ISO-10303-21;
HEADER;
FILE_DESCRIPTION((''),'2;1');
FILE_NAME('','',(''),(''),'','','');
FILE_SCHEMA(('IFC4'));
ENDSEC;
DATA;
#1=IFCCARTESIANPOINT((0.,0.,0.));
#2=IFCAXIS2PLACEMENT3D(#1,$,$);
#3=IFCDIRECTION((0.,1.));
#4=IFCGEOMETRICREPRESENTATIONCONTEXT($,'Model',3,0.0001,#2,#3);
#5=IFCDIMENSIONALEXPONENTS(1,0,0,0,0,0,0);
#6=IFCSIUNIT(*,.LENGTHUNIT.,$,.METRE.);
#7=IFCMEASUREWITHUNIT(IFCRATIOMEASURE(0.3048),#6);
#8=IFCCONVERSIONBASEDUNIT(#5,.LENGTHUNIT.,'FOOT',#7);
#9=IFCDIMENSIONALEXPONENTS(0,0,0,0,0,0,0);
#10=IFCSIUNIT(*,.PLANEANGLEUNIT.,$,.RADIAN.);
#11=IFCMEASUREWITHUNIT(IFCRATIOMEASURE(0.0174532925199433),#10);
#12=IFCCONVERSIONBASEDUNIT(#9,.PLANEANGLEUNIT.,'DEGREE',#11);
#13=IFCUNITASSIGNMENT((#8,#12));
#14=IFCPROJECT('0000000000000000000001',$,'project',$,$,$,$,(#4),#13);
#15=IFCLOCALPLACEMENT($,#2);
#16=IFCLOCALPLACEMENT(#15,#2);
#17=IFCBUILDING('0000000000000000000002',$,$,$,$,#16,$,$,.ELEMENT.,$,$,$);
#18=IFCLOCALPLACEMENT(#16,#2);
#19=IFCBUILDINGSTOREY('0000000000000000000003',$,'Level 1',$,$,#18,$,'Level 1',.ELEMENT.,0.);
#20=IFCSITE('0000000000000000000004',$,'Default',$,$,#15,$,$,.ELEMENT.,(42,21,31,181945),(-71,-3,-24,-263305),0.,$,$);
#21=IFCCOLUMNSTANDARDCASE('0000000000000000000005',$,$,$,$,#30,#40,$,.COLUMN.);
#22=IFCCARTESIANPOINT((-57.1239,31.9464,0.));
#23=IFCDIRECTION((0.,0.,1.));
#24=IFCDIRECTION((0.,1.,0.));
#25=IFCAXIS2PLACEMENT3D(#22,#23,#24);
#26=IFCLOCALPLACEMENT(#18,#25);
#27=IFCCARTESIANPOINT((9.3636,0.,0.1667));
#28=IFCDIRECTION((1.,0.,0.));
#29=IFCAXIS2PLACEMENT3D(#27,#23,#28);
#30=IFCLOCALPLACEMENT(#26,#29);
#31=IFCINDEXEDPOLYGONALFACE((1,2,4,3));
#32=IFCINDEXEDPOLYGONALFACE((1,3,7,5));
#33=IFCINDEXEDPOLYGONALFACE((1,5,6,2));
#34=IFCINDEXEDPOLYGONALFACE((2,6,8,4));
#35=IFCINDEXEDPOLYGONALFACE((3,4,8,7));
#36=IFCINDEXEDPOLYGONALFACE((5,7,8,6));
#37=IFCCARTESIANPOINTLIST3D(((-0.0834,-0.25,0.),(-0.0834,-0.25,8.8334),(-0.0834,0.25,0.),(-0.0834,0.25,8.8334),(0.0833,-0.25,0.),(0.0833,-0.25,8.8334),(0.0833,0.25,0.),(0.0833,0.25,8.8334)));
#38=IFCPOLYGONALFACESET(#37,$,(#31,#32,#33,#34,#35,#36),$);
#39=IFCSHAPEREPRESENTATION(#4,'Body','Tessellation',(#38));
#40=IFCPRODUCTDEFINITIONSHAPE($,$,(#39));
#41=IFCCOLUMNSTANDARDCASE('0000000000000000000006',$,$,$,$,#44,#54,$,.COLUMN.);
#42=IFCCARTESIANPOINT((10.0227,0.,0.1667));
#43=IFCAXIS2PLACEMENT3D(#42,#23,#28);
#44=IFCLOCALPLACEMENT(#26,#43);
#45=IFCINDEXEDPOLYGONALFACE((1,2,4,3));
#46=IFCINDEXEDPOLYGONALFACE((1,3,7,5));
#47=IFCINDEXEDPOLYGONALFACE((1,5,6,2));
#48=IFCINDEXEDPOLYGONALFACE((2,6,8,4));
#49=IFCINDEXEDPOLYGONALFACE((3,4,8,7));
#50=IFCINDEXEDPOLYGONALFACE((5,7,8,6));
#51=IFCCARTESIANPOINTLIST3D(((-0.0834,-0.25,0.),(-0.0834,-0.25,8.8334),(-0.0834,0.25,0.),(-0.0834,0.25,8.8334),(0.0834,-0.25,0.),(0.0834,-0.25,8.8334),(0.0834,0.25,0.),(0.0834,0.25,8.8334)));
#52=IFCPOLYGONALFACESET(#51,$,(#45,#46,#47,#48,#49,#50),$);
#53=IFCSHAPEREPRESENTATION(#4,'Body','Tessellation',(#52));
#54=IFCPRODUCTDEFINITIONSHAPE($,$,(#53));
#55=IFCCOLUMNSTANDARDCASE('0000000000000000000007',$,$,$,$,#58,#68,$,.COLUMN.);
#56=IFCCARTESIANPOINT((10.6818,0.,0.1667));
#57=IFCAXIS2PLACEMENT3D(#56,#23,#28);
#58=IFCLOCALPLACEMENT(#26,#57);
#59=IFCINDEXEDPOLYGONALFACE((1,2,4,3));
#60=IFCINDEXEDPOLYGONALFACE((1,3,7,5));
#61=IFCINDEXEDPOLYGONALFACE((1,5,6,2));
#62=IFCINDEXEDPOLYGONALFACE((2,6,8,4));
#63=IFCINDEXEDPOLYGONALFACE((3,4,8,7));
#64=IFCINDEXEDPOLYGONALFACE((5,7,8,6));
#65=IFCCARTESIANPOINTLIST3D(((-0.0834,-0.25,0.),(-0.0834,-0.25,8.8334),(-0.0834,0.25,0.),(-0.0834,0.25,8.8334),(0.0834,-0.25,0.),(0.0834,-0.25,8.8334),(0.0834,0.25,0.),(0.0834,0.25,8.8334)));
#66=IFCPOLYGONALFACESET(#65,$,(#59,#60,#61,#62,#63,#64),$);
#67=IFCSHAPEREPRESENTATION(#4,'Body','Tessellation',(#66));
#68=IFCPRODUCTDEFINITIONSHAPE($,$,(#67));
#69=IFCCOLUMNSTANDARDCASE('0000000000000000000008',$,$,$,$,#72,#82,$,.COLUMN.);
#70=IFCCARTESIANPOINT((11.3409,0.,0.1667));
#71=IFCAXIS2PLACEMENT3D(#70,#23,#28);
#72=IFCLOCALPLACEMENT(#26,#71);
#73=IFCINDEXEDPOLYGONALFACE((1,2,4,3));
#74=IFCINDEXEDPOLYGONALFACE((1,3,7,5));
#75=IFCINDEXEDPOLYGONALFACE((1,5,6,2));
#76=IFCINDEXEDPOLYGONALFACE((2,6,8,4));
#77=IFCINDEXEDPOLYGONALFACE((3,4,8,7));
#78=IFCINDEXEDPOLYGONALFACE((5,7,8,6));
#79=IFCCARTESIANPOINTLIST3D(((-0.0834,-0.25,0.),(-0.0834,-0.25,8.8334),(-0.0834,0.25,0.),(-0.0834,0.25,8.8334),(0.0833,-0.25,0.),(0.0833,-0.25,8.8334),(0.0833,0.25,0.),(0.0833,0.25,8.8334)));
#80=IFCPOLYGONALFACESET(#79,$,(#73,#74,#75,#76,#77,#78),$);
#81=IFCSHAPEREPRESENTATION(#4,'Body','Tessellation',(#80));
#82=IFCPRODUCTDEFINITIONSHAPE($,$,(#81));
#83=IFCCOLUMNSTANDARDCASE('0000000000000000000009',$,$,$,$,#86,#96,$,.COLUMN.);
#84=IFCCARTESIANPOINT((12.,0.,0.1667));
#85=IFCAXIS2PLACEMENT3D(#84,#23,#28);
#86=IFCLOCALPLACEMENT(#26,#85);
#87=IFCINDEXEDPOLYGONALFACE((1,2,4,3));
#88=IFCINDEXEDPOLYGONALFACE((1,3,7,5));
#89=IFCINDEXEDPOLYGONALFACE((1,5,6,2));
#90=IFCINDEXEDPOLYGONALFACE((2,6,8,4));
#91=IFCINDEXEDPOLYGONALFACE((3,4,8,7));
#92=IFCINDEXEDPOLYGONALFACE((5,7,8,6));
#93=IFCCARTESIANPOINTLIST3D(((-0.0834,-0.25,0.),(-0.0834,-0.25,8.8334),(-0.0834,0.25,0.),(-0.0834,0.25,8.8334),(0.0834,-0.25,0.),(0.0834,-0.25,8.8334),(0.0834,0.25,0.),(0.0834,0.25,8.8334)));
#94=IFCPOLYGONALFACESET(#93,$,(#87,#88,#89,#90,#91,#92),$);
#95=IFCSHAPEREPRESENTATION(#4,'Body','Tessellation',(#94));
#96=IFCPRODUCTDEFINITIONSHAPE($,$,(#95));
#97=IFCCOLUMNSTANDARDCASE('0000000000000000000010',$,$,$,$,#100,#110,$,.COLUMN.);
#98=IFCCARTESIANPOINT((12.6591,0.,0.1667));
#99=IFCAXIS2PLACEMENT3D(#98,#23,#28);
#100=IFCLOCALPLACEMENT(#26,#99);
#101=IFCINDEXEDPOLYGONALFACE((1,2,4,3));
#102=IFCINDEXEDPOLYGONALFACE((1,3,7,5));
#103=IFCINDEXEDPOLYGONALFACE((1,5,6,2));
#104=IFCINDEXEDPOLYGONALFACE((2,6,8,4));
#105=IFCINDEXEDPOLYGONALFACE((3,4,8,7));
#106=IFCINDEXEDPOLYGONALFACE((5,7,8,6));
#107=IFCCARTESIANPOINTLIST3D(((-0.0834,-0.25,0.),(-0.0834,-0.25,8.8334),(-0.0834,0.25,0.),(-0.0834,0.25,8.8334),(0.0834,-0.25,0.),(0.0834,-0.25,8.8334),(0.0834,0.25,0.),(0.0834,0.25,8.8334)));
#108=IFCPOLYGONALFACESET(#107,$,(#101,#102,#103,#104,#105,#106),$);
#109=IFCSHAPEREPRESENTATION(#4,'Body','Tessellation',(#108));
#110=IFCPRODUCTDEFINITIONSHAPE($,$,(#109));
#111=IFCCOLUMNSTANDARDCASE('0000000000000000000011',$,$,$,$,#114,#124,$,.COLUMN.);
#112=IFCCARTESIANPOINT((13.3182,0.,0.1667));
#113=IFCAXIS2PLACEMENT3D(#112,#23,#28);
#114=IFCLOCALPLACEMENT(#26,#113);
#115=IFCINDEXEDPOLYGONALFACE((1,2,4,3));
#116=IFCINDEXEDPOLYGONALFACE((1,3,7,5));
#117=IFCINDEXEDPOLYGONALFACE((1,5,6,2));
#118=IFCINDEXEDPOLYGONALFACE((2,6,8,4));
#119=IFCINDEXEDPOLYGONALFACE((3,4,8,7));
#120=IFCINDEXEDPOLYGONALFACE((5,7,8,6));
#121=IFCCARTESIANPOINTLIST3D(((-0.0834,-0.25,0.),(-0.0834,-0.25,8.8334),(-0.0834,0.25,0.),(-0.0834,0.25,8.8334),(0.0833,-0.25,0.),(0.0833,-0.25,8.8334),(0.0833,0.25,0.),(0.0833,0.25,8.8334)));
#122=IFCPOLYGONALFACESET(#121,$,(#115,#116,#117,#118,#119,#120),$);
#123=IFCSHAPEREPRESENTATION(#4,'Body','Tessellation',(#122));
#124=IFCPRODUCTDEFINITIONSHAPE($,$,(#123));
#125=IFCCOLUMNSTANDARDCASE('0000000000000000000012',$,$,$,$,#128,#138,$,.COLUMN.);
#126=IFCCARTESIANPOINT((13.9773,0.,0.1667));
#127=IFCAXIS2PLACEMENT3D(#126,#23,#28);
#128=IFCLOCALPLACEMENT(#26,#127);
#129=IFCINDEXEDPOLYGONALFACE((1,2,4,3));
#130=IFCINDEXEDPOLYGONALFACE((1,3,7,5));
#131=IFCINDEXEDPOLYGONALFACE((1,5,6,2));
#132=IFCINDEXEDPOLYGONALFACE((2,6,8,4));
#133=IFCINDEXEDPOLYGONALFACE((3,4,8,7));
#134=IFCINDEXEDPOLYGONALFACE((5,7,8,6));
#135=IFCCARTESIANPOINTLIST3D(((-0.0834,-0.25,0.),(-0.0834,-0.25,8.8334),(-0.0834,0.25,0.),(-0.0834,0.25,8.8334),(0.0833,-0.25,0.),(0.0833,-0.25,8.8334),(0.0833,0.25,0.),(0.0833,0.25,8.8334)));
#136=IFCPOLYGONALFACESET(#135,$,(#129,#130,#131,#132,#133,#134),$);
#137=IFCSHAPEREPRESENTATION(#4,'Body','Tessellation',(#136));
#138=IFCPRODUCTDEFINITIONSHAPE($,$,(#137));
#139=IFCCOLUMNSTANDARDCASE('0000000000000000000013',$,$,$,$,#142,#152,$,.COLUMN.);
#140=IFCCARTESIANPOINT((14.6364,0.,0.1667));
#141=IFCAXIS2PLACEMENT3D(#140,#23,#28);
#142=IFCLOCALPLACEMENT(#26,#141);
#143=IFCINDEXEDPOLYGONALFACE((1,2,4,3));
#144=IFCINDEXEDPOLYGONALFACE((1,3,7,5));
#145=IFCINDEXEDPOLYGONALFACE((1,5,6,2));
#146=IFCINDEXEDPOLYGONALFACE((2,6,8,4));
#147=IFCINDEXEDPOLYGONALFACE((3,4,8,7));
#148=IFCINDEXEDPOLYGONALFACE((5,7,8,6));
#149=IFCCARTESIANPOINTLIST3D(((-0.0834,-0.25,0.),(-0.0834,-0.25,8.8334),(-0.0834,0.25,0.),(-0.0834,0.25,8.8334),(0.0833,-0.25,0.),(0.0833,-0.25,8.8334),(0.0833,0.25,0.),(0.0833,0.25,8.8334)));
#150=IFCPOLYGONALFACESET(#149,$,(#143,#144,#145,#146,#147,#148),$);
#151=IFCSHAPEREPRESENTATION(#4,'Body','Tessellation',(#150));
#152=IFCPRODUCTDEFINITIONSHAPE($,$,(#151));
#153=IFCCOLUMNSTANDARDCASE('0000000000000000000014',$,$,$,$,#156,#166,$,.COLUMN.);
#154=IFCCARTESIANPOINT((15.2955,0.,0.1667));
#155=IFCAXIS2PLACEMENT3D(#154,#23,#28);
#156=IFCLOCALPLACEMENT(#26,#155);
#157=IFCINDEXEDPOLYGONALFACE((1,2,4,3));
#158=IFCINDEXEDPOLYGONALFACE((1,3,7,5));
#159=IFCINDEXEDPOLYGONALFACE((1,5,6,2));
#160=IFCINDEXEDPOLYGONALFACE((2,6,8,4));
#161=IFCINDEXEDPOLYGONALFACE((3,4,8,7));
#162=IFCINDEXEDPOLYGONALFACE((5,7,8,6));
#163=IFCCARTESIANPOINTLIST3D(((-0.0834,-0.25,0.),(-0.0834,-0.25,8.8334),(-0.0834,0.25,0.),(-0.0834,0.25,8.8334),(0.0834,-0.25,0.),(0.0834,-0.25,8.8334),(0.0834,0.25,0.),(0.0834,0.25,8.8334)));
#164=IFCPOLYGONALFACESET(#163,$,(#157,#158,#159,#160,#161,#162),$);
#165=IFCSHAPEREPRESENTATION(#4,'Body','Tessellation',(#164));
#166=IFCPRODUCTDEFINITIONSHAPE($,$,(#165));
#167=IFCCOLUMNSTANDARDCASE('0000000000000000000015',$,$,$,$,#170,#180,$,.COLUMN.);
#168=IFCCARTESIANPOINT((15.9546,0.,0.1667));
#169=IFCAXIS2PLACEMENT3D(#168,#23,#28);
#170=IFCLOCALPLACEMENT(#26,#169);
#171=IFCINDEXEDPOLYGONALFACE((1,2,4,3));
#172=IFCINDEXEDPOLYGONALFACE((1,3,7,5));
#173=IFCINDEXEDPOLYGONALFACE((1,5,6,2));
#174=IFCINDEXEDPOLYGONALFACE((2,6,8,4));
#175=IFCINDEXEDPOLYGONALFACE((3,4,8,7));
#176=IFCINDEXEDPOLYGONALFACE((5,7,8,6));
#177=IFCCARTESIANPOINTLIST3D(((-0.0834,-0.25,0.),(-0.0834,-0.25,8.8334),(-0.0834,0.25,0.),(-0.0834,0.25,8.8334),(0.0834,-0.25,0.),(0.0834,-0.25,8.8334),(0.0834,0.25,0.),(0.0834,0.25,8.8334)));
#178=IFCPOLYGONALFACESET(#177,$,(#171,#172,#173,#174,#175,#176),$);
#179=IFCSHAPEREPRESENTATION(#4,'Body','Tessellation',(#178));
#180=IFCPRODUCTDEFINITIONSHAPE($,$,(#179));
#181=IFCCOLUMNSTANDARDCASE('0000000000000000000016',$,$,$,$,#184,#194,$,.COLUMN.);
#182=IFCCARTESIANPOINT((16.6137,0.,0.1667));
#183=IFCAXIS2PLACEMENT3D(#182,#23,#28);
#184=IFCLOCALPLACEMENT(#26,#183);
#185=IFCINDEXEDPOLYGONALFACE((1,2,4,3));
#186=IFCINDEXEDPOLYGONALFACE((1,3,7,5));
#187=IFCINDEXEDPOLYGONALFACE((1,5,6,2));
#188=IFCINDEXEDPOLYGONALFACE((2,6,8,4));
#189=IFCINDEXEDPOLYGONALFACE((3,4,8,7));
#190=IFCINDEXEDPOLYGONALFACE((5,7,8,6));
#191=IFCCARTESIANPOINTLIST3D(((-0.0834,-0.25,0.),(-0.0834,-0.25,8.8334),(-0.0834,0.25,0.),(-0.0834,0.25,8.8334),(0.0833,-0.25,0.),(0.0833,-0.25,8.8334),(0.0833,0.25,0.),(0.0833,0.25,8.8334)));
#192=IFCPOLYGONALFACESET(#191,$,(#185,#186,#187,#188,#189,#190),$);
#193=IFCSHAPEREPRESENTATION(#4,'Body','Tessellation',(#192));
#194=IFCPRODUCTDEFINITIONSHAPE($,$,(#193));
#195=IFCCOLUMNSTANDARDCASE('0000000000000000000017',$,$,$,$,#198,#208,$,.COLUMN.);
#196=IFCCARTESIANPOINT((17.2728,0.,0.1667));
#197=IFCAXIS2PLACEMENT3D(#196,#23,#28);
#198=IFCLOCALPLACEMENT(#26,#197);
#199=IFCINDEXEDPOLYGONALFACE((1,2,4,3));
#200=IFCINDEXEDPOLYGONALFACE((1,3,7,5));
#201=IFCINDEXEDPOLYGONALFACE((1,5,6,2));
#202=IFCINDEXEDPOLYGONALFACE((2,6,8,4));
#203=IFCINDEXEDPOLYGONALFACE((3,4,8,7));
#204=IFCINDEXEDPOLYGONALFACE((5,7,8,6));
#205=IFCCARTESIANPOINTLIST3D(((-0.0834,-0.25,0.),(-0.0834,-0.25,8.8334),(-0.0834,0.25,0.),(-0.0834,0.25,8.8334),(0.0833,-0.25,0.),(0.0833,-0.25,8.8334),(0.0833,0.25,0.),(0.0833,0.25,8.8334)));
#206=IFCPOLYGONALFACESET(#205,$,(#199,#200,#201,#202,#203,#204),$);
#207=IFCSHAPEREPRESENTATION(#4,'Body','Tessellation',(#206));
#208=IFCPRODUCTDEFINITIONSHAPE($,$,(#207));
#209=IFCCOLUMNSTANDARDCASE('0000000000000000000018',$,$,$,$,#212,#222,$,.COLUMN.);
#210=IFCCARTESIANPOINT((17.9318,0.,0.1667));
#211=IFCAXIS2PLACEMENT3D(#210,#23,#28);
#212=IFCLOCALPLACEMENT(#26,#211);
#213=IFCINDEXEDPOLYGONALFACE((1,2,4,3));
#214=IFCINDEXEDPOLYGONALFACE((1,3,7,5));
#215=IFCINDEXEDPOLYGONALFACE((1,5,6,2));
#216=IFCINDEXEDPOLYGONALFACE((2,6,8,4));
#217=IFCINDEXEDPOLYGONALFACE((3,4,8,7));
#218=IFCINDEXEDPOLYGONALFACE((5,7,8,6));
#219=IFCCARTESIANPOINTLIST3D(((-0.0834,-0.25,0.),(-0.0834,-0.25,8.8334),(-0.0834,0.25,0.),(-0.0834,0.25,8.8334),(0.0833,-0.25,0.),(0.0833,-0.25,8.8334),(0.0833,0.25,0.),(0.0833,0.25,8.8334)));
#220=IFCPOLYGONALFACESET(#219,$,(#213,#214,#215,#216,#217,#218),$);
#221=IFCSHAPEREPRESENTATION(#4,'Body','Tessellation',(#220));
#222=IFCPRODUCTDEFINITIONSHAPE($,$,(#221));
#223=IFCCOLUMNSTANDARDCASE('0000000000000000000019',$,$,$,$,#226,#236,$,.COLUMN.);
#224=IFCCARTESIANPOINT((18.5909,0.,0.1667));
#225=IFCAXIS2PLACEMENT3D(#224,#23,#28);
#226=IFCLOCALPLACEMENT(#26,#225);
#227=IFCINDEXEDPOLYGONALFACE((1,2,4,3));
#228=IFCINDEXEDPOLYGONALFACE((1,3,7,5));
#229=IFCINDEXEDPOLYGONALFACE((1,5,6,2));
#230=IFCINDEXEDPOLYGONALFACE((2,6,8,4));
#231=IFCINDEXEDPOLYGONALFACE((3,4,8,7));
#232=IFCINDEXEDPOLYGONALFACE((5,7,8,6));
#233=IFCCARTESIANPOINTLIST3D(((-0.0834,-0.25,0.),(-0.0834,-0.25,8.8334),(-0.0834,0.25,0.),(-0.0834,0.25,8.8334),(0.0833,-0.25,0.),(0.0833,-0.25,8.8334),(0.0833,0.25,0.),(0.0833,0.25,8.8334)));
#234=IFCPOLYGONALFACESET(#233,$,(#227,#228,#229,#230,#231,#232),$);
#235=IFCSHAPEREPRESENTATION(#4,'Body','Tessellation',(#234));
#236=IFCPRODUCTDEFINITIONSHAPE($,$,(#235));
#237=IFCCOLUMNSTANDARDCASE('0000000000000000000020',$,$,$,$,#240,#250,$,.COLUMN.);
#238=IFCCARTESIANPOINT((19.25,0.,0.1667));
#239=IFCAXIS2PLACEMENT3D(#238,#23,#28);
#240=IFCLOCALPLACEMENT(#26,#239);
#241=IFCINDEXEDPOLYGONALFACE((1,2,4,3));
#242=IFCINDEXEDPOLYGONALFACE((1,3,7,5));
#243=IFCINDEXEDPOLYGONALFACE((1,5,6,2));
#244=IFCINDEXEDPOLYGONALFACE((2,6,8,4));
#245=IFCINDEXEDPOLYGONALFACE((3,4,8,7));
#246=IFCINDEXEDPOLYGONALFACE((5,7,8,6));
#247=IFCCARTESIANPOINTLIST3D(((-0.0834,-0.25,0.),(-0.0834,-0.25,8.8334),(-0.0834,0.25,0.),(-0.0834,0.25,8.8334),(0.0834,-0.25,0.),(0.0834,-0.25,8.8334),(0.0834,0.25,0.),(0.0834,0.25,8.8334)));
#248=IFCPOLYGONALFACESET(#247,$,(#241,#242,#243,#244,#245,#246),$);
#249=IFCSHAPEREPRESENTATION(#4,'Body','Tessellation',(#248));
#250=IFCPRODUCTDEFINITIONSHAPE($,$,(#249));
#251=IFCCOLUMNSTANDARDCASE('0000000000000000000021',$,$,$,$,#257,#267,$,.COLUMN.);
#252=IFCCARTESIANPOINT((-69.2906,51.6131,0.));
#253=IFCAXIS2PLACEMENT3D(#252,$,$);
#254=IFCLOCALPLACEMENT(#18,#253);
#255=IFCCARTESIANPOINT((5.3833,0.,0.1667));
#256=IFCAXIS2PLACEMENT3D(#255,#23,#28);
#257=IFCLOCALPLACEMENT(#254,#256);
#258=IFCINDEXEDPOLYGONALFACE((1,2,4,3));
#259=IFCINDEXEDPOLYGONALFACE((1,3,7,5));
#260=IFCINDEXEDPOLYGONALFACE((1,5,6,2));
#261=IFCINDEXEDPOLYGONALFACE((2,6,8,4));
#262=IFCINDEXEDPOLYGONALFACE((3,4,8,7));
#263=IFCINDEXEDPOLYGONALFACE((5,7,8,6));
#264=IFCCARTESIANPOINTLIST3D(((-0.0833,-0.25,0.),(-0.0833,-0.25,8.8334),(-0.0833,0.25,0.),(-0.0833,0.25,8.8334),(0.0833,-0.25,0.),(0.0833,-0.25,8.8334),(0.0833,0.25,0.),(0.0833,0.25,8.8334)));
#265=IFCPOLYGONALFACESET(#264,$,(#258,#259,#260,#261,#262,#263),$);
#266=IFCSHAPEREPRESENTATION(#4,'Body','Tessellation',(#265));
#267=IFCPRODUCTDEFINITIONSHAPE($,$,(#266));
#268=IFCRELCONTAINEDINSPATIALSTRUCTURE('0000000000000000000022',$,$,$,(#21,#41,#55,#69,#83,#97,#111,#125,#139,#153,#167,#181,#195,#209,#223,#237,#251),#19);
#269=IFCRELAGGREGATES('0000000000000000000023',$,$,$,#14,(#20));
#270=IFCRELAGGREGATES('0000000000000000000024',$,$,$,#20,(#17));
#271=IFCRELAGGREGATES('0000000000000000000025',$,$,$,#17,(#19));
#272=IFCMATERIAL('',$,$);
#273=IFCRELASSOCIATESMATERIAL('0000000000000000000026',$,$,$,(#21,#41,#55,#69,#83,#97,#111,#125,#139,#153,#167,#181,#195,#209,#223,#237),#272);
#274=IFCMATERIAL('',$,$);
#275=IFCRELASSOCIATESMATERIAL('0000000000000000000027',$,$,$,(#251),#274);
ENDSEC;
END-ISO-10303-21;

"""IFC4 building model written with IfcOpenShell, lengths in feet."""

from ifc_helpers import new_model, entity, si_unit, converted_unit, direction, frame, origin, place, context, project, spatial, rectangle, extrude, material, element, save


model = new_model("IFC4")

# Units and contexts
model_context = context("Model", 3, precision=0.0001, world=origin(), true_north=direction((0.0, 1.0)))
ifc_project = project(units=[converted_unit("LENGTHUNIT", "FOOT", entity("IfcRatioMeasure", 0.3048), si_unit("LENGTHUNIT", "METRE"), dimensions=[1, 0, 0, 0, 0, 0, 0]), converted_unit("PLANEANGLEUNIT", "DEGREE", entity("IfcRatioMeasure", 0.0174532925199433), si_unit("PLANEANGLEUNIT", "RADIAN"), dimensions=[0, 0, 0, 0, 0, 0, 0])], contexts=[model_context])

# Site, building, storey
site_placement = place(None, origin())
site = spatial("IfcSite", under=ifc_project, at=site_placement, Name="Default", CompositionType="ELEMENT", RefLatitude=(42, 21, 31, 181945), RefLongitude=(-71, -3, -24, -263305), RefElevation=0.0)
building_placement = place(site_placement, origin())
building = spatial("IfcBuilding", under=site, at=building_placement, CompositionType="ELEMENT")
storey_placement = place(building_placement, origin())
storey = spatial("IfcBuildingStorey", under=building, at=storey_placement, Name="Level 1", LongName="Level 1", CompositionType="ELEMENT", Elevation=0.0)

# Columns
ifc_material_1 = material(Name="")
placement_1 = place(storey_placement, frame((-57.1239, 31.9464, 0.0), z_axis=(0.0, 0.0, 1.0), x_axis=(0.0, 1.0, 0.0)))
for number, where, z_axis, x_axis in (
    (1, (9.3636, 0.0, 0.1667), (0.0, 0.0, 1.0), (1.0, 0.0, 0.0)),
    (2, (10.0227, 0.0, 0.1667), (0.0, 0.0, 1.0), (1.0, 0.0, 0.0)),
    (3, (10.6818, 0.0, 0.1667), (0.0, 0.0, 1.0), (1.0, 0.0, 0.0)),
    (4, (11.3409, 0.0, 0.1667), (0.0, 0.0, 1.0), (1.0, 0.0, 0.0)),
    (5, (12.0, 0.0, 0.1667), (0.0, 0.0, 1.0), (1.0, 0.0, 0.0)),
    (6, (12.6591, 0.0, 0.1667), (0.0, 0.0, 1.0), (1.0, 0.0, 0.0)),
    (7, (13.3182, 0.0, 0.1667), (0.0, 0.0, 1.0), (1.0, 0.0, 0.0)),
    (8, (13.9773, 0.0, 0.1667), (0.0, 0.0, 1.0), (1.0, 0.0, 0.0)),
    (9, (14.6364, 0.0, 0.1667), (0.0, 0.0, 1.0), (1.0, 0.0, 0.0)),
    (10, (15.2955, 0.0, 0.1667), (0.0, 0.0, 1.0), (1.0, 0.0, 0.0)),
    (11, (15.9546, 0.0, 0.1667), (0.0, 0.0, 1.0), (1.0, 0.0, 0.0)),
    (12, (16.6137, 0.0, 0.1667), (0.0, 0.0, 1.0), (1.0, 0.0, 0.0)),
    (13, (17.2728, 0.0, 0.1667), (0.0, 0.0, 1.0), (1.0, 0.0, 0.0)),
    (14, (17.9318, 0.0, 0.1667), (0.0, 0.0, 1.0), (1.0, 0.0, 0.0)),
    (15, (18.5909, 0.0, 0.1667), (0.0, 0.0, 1.0), (1.0, 0.0, 0.0)),
    (16, (19.25, 0.0, 0.1667), (0.0, 0.0, 1.0), (1.0, 0.0, 0.0)),
):
    element("IfcColumnStandardCase", number, at=place(placement_1, frame(where, z_axis=z_axis, x_axis=x_axis)), inside=storey, material=ifc_material_1, PredefinedType="COLUMN", context=model_context, shape_type="SweptSolid", body=[
        extrude(rectangle(XDim=0.1667, YDim=0.5), origin(), (0.0, 0.0, 1.0), 8.8334),
    ])
ifc_material_2 = material(Name="")
placement_2 = place(storey_placement, frame((-69.2906, 51.6131, 0.0)))
for number, where, z_axis, x_axis in (
    (17, (5.3833, 0.0, 0.1667), (0.0, 0.0, 1.0), (1.0, 0.0, 0.0)),
):
    element("IfcColumnStandardCase", number, at=place(placement_2, frame(where, z_axis=z_axis, x_axis=x_axis)), inside=storey, material=ifc_material_2, PredefinedType="COLUMN", context=model_context, shape_type="SweptSolid", body=[
        extrude(rectangle(XDim=0.1667, YDim=0.5), origin(), (0.0, 0.0, 1.0), 8.8334),
    ])

save(model, "model.ifc")
